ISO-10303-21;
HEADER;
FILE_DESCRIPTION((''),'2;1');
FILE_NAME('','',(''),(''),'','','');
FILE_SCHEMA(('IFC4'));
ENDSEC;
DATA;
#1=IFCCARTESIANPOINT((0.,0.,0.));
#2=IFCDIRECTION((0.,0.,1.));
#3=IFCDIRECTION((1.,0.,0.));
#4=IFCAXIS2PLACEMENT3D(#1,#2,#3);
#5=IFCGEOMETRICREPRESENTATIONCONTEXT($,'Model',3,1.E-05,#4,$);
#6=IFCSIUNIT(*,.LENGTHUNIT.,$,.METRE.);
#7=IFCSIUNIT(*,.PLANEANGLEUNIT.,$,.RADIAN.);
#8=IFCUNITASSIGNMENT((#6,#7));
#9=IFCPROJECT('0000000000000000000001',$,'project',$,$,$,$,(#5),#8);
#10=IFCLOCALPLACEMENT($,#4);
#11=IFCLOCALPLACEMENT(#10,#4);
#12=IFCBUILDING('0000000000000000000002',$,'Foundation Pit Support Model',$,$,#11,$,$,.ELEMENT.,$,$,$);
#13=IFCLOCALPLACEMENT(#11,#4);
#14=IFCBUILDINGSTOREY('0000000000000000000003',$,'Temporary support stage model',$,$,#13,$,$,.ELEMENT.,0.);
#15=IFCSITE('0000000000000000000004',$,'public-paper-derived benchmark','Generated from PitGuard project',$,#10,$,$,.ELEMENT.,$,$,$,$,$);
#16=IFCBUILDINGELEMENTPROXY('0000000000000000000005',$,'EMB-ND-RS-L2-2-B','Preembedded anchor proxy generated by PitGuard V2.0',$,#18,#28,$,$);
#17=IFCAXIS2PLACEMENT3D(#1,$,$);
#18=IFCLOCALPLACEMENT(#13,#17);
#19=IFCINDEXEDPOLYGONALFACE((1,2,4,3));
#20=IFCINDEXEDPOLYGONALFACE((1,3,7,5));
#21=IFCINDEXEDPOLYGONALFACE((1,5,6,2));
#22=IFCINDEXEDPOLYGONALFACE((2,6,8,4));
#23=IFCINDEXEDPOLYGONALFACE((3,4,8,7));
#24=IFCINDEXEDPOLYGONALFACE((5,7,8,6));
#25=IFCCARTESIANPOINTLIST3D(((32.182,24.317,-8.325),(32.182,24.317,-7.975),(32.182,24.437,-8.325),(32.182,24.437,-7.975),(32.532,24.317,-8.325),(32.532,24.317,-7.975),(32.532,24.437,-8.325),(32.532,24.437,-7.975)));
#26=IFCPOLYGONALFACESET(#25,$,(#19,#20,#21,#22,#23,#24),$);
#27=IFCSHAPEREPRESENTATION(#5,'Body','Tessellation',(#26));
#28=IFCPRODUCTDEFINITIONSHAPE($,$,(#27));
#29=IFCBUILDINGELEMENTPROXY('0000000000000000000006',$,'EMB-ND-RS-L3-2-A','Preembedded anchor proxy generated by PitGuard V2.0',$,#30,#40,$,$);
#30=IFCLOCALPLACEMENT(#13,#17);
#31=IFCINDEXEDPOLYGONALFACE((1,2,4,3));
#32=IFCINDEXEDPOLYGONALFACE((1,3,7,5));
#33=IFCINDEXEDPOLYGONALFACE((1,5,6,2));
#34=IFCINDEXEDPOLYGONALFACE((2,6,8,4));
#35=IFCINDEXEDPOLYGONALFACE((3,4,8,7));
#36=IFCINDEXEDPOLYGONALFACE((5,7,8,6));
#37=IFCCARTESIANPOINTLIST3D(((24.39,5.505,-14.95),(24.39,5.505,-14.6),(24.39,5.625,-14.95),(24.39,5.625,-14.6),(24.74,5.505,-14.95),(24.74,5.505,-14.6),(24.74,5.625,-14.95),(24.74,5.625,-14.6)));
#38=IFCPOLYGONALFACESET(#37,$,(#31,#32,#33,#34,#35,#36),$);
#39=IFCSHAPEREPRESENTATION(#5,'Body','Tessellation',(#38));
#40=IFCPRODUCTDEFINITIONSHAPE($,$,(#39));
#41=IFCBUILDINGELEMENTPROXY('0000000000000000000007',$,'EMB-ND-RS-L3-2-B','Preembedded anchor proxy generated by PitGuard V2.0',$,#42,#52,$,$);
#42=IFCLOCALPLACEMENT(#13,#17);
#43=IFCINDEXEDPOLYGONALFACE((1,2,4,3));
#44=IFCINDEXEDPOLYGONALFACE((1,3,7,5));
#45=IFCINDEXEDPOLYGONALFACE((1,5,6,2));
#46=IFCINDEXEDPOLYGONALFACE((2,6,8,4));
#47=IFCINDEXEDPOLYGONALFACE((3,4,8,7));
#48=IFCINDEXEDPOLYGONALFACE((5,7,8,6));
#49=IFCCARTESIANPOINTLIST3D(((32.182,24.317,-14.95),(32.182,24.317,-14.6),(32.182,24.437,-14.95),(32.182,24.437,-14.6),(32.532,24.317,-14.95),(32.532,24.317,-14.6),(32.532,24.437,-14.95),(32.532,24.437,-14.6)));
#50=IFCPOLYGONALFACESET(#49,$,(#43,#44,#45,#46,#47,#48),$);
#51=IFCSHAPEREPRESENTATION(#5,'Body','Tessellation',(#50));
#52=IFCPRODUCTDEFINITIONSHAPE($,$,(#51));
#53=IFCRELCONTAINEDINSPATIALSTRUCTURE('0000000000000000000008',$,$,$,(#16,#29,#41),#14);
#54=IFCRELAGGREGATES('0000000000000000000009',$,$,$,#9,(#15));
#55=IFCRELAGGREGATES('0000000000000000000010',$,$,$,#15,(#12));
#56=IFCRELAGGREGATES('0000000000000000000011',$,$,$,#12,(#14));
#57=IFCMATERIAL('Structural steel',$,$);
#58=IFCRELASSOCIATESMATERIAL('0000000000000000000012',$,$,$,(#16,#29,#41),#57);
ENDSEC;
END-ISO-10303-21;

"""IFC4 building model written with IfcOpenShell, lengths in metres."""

from ifc_helpers import new_model, si_unit, frame, origin_with_axes, origin_2d, place, context, project, spatial, rectangle, extrude, material, element, save


model = new_model("IFC4")

# Units and contexts
model_context = context("Model", 3, precision=1e-05, world=origin_with_axes())
ifc_project = project(units=[si_unit("LENGTHUNIT", "METRE"), si_unit("PLANEANGLEUNIT", "RADIAN")], contexts=[model_context])

# Site, building, storey
site_placement = place(None, origin_with_axes())
site = spatial("IfcSite", under=ifc_project, at=site_placement, Name="public-paper-derived benchmark", Description="Generated from PitGuard project", CompositionType="ELEMENT")
building_placement = place(site_placement, origin_with_axes())
building = spatial("IfcBuilding", under=site, at=building_placement, Name="Foundation Pit Support Model", CompositionType="ELEMENT")
storey_placement = place(building_placement, origin_with_axes())
storey = spatial("IfcBuildingStorey", under=building, at=storey_placement, Name="Temporary support stage model", CompositionType="ELEMENT", Elevation=0.0)

# Shared definitions
ifc_material_1 = material(Name="Structural steel")

# Building element proxies
for number, where, z_axis, x_axis, name in (
    (1, (32.357, 24.377, -8.325), (0.0, 0.0, 1.0), (1.0, 0.0, 0.0), "EMB-ND-RS-L2-2-B"),
    (2, (24.565, 5.565, -14.95), (0.0, 0.0, 1.0), (1.0, 0.0, 0.0), "EMB-ND-RS-L3-2-A"),
    (3, (32.357, 24.377, -14.95), (0.0, 0.0, 1.0), (1.0, 0.0, 0.0), "EMB-ND-RS-L3-2-B"),
):
    element("IfcBuildingElementProxy", number, at=place(storey_placement, frame(where, z_axis=z_axis, x_axis=x_axis)), inside=storey, material=ifc_material_1, Name=name, Description="Preembedded anchor proxy generated by PitGuard V2.0", context=model_context, shape_type="SweptSolid", body=[
        extrude(rectangle(XDim=0.35, YDim=0.12, at=origin_2d()), origin_with_axes(), (0.0, 0.0, 1.0), 0.35),
    ])

save(model, "model.ifc")
